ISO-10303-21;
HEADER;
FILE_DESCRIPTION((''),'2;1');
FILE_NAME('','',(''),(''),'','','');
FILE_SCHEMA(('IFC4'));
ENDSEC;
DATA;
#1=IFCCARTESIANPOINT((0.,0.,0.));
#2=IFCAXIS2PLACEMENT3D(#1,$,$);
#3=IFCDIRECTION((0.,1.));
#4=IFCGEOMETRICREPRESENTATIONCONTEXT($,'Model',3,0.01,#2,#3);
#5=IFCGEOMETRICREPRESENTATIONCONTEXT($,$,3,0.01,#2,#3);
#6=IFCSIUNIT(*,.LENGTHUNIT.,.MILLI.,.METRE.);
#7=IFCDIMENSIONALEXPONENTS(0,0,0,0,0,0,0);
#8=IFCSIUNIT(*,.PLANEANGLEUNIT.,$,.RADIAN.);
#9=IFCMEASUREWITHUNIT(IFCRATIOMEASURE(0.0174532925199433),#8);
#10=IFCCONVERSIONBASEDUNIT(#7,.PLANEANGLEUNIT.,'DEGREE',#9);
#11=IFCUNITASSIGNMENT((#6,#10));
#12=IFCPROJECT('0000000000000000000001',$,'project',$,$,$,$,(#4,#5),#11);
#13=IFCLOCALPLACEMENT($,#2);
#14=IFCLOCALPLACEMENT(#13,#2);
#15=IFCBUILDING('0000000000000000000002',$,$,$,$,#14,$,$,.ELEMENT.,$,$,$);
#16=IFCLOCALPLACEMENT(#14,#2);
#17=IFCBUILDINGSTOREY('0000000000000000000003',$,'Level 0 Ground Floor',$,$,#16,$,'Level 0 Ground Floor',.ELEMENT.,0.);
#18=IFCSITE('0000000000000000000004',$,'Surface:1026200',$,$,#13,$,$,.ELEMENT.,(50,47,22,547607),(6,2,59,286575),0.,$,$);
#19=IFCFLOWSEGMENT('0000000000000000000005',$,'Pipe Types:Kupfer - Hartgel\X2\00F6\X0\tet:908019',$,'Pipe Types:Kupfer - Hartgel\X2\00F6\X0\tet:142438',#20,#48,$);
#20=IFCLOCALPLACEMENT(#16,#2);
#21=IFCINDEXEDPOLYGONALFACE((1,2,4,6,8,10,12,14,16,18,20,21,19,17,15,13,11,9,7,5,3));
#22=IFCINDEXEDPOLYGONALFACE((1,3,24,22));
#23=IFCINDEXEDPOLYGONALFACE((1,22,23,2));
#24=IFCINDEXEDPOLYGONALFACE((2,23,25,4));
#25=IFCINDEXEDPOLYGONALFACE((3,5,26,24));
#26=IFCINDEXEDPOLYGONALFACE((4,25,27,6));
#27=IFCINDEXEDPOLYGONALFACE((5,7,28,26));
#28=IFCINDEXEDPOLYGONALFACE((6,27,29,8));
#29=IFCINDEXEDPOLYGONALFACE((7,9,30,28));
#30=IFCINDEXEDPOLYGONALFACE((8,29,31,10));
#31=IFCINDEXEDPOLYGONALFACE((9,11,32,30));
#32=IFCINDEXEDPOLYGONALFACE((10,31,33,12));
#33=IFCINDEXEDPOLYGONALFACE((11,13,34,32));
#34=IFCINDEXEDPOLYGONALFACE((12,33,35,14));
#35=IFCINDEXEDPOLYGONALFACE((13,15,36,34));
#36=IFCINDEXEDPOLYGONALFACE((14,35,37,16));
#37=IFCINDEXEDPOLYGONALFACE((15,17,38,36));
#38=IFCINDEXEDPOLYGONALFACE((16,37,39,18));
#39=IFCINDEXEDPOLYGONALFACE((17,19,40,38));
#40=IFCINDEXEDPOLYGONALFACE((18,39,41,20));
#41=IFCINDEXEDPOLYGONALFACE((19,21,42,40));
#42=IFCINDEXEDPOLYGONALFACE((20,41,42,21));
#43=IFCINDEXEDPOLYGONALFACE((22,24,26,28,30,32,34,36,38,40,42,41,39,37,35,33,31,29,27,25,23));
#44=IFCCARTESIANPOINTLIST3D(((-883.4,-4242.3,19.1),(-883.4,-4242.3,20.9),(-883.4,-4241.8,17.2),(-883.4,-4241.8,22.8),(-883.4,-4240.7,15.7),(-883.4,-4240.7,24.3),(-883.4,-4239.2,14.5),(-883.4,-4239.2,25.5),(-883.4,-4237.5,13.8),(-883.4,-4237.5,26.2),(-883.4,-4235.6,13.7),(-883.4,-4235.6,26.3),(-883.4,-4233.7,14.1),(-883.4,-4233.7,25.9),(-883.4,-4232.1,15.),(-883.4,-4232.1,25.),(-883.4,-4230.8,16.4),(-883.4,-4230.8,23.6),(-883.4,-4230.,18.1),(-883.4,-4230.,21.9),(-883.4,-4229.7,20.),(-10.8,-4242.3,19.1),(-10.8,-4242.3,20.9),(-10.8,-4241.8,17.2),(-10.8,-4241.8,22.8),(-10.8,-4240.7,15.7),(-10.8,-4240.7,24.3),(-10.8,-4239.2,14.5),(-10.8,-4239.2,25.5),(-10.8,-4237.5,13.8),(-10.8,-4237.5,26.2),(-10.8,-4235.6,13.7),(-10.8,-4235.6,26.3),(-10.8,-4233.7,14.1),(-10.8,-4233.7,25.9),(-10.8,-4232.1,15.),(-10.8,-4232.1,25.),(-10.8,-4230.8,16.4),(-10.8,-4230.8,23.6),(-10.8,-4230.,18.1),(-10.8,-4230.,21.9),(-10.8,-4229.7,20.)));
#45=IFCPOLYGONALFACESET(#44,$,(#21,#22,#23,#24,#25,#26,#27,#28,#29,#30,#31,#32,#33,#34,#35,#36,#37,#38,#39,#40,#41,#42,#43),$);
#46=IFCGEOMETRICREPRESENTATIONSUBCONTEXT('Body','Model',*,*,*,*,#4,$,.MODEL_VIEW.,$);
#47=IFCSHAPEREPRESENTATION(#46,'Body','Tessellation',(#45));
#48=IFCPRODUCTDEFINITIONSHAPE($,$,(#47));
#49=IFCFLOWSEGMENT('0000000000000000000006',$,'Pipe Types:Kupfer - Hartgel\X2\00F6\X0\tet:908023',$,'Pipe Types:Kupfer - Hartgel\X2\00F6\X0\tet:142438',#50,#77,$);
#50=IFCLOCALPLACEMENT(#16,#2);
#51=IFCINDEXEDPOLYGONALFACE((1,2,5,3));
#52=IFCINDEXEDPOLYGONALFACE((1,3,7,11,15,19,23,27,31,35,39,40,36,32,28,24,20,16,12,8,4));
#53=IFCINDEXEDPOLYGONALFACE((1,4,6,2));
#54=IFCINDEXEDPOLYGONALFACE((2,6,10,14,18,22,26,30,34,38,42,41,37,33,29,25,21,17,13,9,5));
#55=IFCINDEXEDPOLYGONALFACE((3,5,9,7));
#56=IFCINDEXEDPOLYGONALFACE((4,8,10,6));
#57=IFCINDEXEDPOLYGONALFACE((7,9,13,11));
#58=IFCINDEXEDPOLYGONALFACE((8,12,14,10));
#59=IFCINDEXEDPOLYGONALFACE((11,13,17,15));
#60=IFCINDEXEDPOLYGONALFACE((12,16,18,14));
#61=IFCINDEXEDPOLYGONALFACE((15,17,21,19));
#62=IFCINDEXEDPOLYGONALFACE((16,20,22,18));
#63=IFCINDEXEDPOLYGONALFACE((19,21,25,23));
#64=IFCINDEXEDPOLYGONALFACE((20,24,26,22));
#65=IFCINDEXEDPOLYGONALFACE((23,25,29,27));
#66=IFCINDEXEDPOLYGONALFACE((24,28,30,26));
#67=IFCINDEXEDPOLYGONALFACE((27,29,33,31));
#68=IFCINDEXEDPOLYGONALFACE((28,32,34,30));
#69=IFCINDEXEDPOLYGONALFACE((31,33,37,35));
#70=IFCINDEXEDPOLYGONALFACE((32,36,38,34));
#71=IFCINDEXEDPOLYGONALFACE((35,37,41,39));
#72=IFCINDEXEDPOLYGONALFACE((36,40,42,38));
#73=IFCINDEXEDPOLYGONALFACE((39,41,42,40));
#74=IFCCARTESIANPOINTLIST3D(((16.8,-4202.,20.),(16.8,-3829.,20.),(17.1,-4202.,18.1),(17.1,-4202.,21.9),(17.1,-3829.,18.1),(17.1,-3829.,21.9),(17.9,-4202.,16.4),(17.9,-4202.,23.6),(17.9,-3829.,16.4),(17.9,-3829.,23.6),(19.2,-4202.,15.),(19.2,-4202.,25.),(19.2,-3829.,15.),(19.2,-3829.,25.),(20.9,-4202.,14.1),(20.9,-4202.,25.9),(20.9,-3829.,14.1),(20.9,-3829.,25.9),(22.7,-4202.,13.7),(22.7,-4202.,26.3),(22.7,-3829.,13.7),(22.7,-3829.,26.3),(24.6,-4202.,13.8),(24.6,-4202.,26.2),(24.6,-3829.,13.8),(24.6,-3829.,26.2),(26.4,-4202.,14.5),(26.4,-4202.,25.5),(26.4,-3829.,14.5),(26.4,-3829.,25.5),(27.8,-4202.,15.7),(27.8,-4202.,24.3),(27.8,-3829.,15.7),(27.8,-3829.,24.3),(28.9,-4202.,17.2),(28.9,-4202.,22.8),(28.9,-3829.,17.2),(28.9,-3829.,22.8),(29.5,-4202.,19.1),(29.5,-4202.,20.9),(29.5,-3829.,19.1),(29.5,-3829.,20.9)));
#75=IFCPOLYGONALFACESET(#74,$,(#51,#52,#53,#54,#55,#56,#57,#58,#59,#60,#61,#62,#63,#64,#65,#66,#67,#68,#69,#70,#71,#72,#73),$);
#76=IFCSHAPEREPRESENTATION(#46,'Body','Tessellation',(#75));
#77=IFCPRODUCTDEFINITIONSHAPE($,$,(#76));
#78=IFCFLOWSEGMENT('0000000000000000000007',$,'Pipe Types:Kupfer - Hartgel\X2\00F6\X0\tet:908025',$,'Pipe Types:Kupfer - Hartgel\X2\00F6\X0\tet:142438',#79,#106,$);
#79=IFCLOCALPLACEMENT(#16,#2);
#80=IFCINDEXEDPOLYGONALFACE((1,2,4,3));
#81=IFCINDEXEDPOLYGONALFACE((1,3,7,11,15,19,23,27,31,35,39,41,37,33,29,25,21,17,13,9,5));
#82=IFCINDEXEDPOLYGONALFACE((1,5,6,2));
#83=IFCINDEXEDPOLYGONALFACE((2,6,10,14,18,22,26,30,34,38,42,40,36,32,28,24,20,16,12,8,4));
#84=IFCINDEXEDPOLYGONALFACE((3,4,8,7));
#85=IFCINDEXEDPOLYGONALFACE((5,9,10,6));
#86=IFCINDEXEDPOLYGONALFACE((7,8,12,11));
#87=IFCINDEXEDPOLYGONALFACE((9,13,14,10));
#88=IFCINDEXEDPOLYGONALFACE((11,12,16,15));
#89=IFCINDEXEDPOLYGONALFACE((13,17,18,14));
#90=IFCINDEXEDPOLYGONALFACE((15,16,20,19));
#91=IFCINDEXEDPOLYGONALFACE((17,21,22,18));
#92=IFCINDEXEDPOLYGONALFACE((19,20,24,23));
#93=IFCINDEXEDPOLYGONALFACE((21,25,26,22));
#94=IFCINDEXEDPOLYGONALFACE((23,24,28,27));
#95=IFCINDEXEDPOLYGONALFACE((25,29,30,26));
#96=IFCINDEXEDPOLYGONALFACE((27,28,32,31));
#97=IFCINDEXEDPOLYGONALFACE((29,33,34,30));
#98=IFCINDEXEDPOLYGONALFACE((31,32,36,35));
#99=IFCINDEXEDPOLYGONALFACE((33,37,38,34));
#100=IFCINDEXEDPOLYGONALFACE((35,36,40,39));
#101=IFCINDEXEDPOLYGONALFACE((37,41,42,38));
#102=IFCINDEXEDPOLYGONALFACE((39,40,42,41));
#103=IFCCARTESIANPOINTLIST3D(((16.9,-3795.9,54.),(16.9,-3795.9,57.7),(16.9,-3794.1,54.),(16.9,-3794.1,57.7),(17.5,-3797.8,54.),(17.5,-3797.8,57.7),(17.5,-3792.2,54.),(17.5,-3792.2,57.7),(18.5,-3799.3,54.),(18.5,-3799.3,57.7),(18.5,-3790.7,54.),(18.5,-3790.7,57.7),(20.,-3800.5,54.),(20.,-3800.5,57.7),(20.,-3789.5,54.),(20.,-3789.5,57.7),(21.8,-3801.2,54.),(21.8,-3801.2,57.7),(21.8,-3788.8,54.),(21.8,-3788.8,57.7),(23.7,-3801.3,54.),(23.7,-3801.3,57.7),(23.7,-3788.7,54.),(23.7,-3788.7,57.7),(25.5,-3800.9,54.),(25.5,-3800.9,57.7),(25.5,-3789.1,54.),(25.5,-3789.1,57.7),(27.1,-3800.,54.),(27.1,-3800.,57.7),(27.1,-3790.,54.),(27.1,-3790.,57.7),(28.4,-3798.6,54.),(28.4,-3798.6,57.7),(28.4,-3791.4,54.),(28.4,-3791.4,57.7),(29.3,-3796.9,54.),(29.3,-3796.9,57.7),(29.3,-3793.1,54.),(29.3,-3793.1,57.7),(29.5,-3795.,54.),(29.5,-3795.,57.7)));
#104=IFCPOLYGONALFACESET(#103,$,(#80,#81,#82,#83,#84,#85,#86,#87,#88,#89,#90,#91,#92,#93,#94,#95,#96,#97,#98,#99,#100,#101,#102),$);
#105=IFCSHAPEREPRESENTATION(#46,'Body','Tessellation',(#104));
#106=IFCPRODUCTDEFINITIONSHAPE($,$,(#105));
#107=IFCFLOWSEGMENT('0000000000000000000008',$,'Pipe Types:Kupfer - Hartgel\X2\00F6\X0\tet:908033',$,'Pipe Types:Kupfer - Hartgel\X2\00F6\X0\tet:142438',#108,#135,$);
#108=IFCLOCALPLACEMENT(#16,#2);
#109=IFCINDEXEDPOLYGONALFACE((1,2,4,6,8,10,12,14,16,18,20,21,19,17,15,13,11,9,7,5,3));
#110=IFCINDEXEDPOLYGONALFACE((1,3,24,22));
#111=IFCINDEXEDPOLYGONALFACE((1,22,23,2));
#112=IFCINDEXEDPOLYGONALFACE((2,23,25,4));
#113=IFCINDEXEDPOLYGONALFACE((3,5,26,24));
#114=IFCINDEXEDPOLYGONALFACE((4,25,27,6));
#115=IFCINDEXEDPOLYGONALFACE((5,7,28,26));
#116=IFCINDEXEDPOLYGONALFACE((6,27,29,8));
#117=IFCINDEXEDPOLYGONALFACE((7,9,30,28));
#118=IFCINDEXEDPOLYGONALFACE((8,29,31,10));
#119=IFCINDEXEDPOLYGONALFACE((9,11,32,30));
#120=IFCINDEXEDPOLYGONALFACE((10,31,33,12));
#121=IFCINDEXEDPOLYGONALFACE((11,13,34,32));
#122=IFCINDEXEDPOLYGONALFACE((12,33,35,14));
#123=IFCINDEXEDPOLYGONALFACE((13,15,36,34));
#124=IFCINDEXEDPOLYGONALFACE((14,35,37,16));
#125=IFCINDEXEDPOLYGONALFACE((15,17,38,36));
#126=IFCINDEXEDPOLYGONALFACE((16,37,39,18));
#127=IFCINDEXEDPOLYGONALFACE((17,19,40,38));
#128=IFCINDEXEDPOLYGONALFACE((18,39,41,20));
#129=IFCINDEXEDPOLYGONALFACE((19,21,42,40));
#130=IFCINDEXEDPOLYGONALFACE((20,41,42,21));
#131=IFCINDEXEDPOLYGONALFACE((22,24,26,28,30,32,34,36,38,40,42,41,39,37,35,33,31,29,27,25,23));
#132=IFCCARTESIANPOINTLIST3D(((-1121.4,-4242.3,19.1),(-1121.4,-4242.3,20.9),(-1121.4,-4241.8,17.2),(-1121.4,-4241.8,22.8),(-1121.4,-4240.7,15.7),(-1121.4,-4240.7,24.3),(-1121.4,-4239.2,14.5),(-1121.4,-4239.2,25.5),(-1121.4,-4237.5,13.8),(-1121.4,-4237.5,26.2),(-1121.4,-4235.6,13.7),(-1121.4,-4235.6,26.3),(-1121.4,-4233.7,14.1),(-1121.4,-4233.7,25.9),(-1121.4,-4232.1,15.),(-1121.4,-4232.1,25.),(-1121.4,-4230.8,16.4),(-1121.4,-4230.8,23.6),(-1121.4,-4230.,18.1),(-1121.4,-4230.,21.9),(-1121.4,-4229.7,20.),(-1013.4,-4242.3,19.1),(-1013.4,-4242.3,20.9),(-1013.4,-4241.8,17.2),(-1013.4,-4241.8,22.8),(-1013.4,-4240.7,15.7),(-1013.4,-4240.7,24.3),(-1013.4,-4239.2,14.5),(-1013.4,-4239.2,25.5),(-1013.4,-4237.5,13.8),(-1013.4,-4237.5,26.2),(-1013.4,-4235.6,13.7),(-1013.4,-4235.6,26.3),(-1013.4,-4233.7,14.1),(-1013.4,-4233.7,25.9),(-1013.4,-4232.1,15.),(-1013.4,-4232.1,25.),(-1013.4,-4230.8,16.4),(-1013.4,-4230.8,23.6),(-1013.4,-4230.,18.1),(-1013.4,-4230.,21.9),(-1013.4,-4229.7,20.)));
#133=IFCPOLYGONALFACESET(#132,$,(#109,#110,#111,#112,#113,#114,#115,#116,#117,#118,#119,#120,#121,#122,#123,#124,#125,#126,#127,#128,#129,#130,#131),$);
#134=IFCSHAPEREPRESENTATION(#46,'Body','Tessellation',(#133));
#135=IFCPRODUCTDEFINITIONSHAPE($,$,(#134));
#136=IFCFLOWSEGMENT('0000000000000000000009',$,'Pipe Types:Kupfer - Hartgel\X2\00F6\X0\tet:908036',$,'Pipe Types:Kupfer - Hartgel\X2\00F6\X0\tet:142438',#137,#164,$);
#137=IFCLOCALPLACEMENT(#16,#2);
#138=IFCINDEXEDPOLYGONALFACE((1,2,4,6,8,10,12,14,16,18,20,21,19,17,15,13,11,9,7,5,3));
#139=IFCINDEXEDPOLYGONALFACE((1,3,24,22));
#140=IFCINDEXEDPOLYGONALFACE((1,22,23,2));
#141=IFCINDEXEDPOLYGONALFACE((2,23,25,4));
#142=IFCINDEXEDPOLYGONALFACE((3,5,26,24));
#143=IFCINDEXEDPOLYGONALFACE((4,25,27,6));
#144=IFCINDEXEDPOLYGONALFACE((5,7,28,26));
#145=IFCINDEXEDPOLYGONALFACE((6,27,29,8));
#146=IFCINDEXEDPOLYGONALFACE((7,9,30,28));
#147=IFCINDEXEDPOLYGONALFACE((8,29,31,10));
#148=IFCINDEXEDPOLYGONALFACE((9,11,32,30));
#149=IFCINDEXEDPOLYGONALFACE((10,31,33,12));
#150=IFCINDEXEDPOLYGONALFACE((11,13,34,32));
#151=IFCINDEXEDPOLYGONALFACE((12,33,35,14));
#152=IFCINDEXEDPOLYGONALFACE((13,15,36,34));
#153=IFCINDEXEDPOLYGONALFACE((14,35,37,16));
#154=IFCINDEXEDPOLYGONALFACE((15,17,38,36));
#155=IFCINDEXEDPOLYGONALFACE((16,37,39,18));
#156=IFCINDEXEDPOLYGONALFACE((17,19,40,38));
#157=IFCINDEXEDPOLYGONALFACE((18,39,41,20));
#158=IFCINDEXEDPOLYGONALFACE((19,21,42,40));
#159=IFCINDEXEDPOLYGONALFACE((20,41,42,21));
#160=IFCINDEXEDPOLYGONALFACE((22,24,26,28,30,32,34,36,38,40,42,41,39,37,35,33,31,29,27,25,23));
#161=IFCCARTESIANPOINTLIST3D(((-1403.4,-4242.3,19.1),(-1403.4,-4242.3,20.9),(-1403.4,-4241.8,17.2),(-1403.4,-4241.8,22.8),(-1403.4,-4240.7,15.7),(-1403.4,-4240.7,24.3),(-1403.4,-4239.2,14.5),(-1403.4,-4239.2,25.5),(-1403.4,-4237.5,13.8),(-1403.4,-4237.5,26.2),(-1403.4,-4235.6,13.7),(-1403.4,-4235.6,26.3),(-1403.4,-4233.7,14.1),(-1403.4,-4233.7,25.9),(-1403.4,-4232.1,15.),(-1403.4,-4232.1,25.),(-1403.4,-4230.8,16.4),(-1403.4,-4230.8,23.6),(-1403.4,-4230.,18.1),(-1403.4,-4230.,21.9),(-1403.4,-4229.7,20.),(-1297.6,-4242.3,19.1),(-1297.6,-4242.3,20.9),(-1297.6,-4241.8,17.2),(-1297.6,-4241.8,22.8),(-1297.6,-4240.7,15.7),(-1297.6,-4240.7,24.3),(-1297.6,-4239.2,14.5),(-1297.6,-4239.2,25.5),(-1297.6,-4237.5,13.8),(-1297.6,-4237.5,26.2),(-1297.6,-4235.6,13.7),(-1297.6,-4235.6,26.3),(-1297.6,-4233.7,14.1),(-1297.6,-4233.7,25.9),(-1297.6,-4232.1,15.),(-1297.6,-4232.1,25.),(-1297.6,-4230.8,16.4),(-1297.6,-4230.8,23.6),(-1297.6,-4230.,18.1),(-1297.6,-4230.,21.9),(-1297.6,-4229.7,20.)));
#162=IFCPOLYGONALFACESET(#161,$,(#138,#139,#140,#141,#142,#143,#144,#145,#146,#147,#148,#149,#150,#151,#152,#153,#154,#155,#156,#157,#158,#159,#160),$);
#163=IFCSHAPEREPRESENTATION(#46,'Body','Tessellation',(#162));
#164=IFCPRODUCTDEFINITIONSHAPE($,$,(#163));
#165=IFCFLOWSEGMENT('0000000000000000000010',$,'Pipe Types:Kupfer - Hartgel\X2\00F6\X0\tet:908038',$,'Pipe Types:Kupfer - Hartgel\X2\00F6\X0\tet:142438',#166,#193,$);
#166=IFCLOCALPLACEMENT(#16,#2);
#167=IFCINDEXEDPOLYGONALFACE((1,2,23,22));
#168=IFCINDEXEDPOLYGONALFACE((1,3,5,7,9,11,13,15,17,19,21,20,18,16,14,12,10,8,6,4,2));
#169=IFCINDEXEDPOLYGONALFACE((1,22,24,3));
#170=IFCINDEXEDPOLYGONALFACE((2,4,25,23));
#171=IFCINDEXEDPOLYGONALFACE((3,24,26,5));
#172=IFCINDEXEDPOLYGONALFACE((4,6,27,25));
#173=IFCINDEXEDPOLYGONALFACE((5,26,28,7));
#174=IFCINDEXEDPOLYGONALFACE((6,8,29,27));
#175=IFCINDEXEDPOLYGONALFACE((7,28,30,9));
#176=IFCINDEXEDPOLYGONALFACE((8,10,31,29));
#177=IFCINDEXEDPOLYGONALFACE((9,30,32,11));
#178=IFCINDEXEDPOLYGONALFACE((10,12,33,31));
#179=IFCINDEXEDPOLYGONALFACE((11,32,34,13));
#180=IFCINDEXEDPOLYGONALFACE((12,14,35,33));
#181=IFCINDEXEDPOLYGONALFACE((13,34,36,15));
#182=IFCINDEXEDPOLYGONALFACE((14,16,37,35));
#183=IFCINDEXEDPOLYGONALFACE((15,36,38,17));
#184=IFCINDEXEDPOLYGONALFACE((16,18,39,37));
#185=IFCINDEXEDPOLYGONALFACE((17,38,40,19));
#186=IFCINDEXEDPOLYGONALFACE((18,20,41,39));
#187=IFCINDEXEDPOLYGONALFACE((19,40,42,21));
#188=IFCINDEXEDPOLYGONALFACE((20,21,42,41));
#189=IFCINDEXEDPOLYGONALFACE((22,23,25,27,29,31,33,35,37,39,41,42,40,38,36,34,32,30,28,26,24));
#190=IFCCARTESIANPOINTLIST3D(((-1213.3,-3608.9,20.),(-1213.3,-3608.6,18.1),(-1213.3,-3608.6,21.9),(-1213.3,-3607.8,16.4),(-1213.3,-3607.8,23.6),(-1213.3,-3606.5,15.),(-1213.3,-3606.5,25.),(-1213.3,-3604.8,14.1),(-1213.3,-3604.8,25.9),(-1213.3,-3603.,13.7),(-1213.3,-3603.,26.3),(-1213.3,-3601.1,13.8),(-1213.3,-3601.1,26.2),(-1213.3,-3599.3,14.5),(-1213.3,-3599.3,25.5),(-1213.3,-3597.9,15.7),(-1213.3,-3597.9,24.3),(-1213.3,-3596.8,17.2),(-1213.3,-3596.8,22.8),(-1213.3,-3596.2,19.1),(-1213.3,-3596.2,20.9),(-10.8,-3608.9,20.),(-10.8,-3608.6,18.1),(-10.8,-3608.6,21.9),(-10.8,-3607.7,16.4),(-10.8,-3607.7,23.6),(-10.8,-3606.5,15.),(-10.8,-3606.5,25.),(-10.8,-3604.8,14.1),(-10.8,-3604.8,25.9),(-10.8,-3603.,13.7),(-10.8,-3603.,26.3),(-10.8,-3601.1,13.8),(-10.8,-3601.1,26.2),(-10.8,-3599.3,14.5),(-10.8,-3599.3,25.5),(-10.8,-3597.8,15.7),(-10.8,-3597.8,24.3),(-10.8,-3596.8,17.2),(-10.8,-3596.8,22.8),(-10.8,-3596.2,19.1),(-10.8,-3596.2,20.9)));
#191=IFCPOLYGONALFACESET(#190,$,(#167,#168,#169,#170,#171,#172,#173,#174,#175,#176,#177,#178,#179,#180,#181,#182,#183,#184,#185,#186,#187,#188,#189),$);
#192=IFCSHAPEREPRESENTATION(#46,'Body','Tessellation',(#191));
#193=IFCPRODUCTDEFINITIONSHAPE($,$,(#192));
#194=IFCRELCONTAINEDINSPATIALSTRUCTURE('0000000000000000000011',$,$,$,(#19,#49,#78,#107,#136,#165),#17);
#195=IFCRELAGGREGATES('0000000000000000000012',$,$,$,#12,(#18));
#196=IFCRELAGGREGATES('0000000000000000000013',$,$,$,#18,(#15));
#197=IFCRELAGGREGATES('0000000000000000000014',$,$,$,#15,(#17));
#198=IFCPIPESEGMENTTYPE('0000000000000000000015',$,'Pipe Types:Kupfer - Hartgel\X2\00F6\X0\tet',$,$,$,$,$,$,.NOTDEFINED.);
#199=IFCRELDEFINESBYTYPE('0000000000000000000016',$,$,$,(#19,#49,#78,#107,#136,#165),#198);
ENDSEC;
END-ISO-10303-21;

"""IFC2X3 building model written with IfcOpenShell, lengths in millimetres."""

from ifc_helpers import new_model, entity, si_unit, converted_unit, direction, frame, frame_2d, origin, place, context, subcontext, project, spatial, circle, extrude, type_object, element, save


model = new_model("IFC2X3")

# Units and contexts
model_context = context("Model", 3, precision=0.01, world=origin(), true_north=direction((0.0, 1.0)))
context_of_model = context(None, 3, precision=0.01, world=origin(), true_north=direction((0.0, 1.0)))
body_context = subcontext(model_context, "Body", "Model", "MODEL_VIEW")
ifc_project = project(units=[si_unit("LENGTHUNIT", "METRE", prefix="MILLI"), converted_unit("PLANEANGLEUNIT", "DEGREE", entity("IfcRatioMeasure", 0.0174532925199433), si_unit("PLANEANGLEUNIT", "RADIAN"), dimensions=[0, 0, 0, 0, 0, 0, 0])], contexts=[model_context, context_of_model])

# Site, building, storey
site_placement = place(None, origin())
site = spatial("IfcSite", under=ifc_project, at=site_placement, Name="Surface:1026200", CompositionType="ELEMENT", RefLatitude=(50, 47, 22, 547607), RefLongitude=(6, 2, 59, 286575), RefElevation=0.0)
building_placement = place(site_placement, origin())
building = spatial("IfcBuilding", under=site, at=building_placement, CompositionType="ELEMENT")
storey_placement = place(building_placement, origin())
storey = spatial("IfcBuildingStorey", under=building, at=storey_placement, Name="Level 0 Ground Floor", LongName="Level 0 Ground Floor", CompositionType="ELEMENT", Elevation=0.0)

# Flow segments
pipe_segment_type = type_object("IfcPipeSegmentType", Name="Pipe Types:Kupfer - Hartgelötet", PredefinedType="NOTDEFINED")
flow_segment_1_placement = place(storey_placement, origin())
element("IfcFlowSegment", 1, at=flow_segment_1_placement, inside=storey, type_object=pipe_segment_type, Name="Pipe Types:Kupfer - Hartgelötet:908019", ObjectType="Pipe Types:Kupfer - Hartgelötet:142438", context=body_context, shape_type="SweptSolid", body=[
    extrude(circle(Radius=6.3, at=frame_2d((0.0, 0.0), x_axis=(1.0, 0.0))), frame((-883.4, -4236.0, 20.0), z_axis=(1.0, 0.0, 0.0), x_axis=(0.0, 1.0, 0.0)), (0.0, 0.0, 1.0), 872.6),
])
flow_segment_2_placement = place(storey_placement, origin())
element("IfcFlowSegment", 2, at=flow_segment_2_placement, inside=storey, type_object=pipe_segment_type, Name="Pipe Types:Kupfer - Hartgelötet:908023", ObjectType="Pipe Types:Kupfer - Hartgelötet:142438", context=body_context, shape_type="SweptSolid", body=[
    extrude(circle(Radius=6.3, at=frame_2d((0.0, 0.0), x_axis=(1.0, 0.0))), frame((23.2, -4202.0, 20.0), z_axis=(0.0, 1.0, 0.0), x_axis=(-1.0, 0.0, 0.0)), (0.0, 0.0, 1.0), 373.0),
])
flow_segment_3_placement = place(storey_placement, origin())
element("IfcFlowSegment", 3, at=flow_segment_3_placement, inside=storey, type_object=pipe_segment_type, Name="Pipe Types:Kupfer - Hartgelötet:908025", ObjectType="Pipe Types:Kupfer - Hartgelötet:142438", context=body_context, shape_type="SweptSolid", body=[
    extrude(circle(Radius=6.3, at=frame_2d((0.0, 0.0), x_axis=(1.0, 0.0))), frame((23.2, -3795.0, 54.0)), (0.0, 0.0, 1.0), 3.7),
])
flow_segment_4_placement = place(storey_placement, origin())
element("IfcFlowSegment", 4, at=flow_segment_4_placement, inside=storey, type_object=pipe_segment_type, Name="Pipe Types:Kupfer - Hartgelötet:908033", ObjectType="Pipe Types:Kupfer - Hartgelötet:142438", context=body_context, shape_type="SweptSolid", body=[
    extrude(circle(Radius=6.3, at=frame_2d((0.0, 0.0), x_axis=(1.0, 0.0))), frame((-1121.4, -4236.0, 20.0), z_axis=(1.0, 0.0, 0.0), x_axis=(0.0, 1.0, 0.0)), (0.0, 0.0, 1.0), 108.0),
])
flow_segment_5_placement = place(storey_placement, origin())
element("IfcFlowSegment", 5, at=flow_segment_5_placement, inside=storey, type_object=pipe_segment_type, Name="Pipe Types:Kupfer - Hartgelötet:908036", ObjectType="Pipe Types:Kupfer - Hartgelötet:142438", context=body_context, shape_type="SweptSolid", body=[
    extrude(circle(Radius=6.3, at=frame_2d((0.0, 0.0), x_axis=(1.0, 0.0))), frame((-1403.4, -4236.0, 20.0), z_axis=(1.0, 0.0, 0.0), x_axis=(0.0, 1.0, 0.0)), (0.0, 0.0, 1.0), 105.8),
])
flow_segment_6_placement = place(storey_placement, origin())
element("IfcFlowSegment", 6, at=flow_segment_6_placement, inside=storey, type_object=pipe_segment_type, Name="Pipe Types:Kupfer - Hartgelötet:908038", ObjectType="Pipe Types:Kupfer - Hartgelötet:142438", context=body_context, shape_type="SweptSolid", body=[
    extrude(circle(Radius=6.3, at=frame_2d((0.0, 0.0), x_axis=(1.0, 0.0))), frame((-1213.3, -3602.5, 20.0), z_axis=(1.0, 0.000017, 0.0), x_axis=(0.000017, -1.0, 0.0)), (0.0, 0.0, 1.0), 1202.5),
])

save(model, "model.ifc")
